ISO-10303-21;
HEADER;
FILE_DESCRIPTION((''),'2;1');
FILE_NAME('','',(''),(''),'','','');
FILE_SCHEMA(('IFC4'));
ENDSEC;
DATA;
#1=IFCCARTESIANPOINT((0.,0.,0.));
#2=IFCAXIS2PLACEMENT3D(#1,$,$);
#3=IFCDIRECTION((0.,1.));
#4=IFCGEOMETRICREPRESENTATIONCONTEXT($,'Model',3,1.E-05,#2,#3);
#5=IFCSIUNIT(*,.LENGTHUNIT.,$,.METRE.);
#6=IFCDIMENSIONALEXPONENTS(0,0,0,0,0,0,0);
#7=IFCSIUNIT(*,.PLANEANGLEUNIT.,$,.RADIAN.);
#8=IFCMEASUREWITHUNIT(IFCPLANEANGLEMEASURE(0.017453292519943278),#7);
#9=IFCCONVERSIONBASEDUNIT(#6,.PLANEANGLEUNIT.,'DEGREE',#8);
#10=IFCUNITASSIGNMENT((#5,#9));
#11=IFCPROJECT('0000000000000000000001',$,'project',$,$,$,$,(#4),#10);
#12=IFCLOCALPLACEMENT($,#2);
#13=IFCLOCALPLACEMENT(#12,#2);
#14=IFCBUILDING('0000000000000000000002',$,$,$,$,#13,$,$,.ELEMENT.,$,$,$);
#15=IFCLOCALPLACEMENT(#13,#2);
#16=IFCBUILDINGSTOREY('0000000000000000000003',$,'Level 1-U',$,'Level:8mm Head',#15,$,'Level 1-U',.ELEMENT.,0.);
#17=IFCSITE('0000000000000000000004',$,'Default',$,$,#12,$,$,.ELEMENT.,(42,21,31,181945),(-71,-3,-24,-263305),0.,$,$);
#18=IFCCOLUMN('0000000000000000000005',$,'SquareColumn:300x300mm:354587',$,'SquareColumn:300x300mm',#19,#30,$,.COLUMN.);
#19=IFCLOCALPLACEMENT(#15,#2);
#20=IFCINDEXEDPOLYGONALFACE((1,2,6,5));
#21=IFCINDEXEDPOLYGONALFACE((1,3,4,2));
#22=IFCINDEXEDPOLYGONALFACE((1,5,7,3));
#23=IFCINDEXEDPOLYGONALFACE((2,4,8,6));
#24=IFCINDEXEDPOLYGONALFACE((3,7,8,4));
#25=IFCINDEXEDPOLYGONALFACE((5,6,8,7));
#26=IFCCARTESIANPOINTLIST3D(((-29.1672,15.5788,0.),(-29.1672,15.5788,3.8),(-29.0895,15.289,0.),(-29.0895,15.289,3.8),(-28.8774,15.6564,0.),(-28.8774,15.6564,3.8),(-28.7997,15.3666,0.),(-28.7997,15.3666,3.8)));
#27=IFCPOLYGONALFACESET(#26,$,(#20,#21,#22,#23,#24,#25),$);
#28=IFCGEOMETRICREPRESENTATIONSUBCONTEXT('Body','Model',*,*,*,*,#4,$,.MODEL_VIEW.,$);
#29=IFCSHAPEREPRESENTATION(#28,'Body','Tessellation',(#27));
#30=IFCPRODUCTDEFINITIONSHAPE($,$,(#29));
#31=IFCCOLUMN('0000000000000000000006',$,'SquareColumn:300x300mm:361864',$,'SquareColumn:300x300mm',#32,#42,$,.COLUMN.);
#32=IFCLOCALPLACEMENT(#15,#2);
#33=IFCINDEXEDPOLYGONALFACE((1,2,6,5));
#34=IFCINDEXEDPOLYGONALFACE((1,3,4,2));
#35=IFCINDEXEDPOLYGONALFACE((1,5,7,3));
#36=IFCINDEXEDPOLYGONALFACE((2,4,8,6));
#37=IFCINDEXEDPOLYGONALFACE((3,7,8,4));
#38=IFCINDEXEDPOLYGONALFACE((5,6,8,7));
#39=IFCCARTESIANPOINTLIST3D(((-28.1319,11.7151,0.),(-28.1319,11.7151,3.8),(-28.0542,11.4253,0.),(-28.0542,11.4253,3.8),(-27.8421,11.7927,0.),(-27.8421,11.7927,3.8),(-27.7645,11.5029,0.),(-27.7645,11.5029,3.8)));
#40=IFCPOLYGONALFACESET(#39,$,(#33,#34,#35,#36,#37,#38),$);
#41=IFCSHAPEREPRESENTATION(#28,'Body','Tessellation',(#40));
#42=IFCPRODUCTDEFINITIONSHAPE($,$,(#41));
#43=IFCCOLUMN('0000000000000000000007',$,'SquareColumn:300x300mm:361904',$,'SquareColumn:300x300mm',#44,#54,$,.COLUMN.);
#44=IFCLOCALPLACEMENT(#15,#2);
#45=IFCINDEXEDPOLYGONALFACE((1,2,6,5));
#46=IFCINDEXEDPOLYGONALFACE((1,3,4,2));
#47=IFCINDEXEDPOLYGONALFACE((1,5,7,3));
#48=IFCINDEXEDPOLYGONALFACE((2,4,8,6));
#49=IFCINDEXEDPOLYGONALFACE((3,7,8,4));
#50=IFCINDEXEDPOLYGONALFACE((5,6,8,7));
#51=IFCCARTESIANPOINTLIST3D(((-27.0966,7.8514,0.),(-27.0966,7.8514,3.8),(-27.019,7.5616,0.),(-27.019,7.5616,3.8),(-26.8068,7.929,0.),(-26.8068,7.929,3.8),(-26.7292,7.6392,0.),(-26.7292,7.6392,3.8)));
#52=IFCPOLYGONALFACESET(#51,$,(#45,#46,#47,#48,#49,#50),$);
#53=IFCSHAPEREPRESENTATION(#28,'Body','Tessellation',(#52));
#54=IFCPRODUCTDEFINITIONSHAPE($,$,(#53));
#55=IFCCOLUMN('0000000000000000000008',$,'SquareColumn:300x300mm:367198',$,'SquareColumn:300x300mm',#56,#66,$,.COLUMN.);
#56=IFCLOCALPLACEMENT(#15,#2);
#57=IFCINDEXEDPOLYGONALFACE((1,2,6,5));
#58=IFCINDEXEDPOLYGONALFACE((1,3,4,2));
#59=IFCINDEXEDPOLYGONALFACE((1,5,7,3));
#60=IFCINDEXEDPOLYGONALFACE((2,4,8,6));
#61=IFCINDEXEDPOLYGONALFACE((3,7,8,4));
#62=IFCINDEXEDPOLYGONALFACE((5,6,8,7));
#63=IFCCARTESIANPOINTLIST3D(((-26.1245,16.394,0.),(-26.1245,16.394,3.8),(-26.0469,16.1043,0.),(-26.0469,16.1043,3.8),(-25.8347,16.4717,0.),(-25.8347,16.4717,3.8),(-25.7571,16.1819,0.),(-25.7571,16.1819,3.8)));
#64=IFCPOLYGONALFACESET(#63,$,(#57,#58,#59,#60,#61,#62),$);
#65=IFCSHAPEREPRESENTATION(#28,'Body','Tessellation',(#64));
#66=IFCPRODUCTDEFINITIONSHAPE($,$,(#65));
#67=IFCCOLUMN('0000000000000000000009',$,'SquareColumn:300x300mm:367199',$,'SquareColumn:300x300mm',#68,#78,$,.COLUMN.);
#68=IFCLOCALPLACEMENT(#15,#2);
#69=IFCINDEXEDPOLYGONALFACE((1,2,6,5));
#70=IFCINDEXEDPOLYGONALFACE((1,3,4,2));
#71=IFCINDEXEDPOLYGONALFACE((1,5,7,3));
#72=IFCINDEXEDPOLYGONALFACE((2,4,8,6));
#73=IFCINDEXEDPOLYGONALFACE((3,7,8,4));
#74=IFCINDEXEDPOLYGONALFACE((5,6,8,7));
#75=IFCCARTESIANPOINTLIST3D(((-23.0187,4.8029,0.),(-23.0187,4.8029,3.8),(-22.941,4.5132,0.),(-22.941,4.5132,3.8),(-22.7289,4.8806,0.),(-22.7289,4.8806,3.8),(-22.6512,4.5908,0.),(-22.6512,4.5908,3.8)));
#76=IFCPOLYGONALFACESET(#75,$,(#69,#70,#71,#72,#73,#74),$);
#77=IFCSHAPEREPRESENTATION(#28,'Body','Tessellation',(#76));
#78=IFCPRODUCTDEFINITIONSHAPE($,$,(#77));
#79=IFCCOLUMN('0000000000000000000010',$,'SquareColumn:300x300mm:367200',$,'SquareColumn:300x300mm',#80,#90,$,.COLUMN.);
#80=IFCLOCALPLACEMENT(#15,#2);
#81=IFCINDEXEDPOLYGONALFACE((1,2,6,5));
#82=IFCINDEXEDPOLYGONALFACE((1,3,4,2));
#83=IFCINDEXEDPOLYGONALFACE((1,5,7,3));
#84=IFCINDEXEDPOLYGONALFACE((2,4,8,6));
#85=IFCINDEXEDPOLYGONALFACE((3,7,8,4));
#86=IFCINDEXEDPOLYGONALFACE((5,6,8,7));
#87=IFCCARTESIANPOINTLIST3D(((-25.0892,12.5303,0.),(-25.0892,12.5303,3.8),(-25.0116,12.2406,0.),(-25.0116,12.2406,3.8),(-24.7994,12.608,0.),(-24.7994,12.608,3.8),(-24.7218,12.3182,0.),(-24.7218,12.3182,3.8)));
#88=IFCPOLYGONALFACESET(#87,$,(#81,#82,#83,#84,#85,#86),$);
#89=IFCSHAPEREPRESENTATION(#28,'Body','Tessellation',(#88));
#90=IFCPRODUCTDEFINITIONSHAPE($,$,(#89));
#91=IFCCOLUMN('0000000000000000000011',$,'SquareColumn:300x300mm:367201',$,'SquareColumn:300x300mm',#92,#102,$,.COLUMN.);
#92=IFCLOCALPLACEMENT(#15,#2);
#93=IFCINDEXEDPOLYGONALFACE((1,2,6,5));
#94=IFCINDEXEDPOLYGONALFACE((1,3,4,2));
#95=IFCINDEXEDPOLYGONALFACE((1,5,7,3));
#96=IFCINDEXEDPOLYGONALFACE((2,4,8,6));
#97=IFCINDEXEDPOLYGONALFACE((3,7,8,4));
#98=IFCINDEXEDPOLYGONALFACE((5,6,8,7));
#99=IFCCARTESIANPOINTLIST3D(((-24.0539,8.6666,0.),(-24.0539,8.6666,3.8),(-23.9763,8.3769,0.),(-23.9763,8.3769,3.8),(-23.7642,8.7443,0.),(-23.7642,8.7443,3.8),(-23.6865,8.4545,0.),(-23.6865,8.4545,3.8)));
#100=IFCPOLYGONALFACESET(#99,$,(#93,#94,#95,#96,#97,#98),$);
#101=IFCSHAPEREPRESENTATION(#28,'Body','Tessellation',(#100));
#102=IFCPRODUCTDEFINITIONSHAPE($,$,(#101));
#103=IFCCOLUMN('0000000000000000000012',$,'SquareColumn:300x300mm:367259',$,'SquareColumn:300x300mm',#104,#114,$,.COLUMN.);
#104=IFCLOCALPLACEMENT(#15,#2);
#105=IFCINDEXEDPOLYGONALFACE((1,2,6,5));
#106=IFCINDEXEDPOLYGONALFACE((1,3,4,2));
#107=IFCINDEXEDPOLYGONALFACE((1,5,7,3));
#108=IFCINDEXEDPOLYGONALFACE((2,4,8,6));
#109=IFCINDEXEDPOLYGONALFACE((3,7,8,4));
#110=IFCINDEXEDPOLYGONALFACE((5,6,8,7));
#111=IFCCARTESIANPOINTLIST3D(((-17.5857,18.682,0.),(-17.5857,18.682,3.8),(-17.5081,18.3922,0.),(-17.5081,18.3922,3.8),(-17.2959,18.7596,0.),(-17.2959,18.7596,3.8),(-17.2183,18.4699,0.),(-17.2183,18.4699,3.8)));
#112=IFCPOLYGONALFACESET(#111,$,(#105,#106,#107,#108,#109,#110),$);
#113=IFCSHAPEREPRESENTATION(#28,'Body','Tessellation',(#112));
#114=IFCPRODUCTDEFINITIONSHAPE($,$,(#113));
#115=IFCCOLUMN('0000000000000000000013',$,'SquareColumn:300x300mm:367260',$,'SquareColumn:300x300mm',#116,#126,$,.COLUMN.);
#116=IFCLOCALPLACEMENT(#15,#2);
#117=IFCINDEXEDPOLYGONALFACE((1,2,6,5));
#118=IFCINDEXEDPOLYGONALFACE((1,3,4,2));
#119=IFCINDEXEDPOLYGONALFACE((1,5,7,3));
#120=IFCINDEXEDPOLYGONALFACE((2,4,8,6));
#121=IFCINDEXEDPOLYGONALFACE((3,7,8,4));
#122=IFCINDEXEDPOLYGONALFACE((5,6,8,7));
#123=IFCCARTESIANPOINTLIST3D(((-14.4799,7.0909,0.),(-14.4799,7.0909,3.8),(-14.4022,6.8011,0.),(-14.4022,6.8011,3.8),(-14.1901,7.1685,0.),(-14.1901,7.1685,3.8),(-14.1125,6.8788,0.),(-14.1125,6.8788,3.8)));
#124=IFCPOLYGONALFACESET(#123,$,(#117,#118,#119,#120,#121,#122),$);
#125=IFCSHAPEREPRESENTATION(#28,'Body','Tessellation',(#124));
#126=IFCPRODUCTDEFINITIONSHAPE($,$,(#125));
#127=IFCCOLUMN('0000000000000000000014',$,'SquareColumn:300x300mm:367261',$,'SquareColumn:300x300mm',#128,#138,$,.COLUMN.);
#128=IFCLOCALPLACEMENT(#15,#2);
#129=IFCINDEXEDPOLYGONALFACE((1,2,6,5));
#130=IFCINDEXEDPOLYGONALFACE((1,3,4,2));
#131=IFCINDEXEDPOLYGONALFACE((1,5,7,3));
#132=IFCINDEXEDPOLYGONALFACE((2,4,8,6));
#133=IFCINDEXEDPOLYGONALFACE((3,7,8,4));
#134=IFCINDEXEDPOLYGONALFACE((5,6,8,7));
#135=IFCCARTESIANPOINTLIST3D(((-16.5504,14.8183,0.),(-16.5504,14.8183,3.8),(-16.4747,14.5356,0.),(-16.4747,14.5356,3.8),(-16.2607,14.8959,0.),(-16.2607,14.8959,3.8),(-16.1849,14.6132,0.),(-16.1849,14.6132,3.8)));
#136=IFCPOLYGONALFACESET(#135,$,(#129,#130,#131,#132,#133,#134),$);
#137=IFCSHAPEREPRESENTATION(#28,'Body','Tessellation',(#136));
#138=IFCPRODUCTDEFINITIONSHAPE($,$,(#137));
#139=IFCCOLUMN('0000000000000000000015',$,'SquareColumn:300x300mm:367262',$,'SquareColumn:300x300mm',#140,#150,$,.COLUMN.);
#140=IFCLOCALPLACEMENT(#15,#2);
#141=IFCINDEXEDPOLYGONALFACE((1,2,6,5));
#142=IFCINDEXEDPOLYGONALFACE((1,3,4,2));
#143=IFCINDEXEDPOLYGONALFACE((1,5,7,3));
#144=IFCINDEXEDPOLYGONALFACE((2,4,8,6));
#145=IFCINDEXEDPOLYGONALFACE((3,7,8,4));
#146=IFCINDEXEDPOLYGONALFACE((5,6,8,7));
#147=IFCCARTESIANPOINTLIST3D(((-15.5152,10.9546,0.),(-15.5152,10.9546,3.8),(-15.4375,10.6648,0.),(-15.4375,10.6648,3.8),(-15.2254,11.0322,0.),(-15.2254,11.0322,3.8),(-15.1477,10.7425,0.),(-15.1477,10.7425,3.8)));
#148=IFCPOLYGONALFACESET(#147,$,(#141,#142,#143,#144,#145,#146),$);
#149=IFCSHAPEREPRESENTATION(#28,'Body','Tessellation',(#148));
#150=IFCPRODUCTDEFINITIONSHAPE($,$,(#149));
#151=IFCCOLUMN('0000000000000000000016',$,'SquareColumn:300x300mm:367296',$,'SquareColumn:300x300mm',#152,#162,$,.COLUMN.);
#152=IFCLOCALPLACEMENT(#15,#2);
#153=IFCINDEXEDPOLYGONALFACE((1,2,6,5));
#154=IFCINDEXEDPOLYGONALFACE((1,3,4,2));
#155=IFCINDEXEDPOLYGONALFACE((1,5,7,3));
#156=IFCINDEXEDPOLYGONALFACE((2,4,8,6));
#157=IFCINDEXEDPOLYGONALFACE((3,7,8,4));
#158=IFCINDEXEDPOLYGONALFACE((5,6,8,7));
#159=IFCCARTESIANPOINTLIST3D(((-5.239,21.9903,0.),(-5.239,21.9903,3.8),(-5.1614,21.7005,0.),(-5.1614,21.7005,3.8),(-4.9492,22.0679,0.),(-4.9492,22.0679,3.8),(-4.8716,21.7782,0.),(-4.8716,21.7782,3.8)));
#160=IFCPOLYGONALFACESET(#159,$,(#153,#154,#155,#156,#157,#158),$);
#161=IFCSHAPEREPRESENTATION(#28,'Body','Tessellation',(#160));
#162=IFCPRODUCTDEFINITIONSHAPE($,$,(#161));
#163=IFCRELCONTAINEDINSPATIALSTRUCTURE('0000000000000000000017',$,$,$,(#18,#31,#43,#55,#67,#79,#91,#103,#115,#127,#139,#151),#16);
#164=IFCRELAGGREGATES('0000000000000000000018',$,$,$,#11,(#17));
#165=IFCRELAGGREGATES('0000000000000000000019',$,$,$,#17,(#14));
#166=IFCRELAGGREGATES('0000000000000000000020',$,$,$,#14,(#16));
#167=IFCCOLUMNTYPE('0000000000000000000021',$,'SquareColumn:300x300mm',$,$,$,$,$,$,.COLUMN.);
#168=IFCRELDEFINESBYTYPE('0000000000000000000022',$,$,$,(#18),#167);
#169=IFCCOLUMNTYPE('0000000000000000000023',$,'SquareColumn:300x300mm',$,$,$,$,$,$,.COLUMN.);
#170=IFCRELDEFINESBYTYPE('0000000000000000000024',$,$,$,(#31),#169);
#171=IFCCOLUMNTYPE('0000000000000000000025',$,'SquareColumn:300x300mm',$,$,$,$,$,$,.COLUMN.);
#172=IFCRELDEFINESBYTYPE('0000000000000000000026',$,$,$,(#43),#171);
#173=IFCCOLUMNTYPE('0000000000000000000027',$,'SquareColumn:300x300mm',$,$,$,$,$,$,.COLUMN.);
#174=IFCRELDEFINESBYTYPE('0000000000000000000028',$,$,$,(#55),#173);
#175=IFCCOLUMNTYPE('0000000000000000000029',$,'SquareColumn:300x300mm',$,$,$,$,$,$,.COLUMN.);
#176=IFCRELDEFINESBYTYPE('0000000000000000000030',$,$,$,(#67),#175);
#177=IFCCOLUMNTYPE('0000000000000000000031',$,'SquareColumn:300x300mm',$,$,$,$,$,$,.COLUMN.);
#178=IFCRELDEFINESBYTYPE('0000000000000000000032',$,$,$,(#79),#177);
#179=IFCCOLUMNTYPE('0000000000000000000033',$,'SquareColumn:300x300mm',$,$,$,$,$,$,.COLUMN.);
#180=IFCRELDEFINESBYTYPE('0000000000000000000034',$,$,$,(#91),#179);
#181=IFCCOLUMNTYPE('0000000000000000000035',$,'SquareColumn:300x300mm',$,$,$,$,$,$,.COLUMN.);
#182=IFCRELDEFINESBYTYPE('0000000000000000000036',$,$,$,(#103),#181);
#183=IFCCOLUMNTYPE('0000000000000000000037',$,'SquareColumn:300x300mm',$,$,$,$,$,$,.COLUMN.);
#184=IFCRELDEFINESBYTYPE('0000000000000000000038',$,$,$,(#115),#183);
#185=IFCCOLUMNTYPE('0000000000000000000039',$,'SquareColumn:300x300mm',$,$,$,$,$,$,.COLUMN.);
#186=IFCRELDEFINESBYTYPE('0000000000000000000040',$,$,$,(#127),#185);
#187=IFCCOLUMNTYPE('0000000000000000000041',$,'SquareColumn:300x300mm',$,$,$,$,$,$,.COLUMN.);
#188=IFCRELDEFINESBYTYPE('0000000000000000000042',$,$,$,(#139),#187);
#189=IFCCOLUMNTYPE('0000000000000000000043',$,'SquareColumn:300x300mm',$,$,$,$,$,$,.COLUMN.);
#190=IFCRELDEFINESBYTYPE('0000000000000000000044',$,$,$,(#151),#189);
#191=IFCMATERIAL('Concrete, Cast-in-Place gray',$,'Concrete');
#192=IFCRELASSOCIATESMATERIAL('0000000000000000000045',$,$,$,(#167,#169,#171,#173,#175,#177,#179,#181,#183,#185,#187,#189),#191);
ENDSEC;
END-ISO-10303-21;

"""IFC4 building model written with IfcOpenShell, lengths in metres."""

from ifc_helpers import new_model, entity, si_unit, converted_unit, direction, frame, frame_2d, origin, origin_2d_with_axis, place, context, subcontext, project, spatial, rectangle, extrude, source, transform, mapped, material, material_profile, profile_set, type_object, type_shapes, element, save


model = new_model("IFC4")

# Units and contexts
model_context = context("Model", 3, precision=1e-05, world=origin(), true_north=direction((0.0, 1.0)))
body_context = subcontext(model_context, "Body", "Model", "MODEL_VIEW")
ifc_project = project(units=[si_unit("LENGTHUNIT", "METRE"), converted_unit("PLANEANGLEUNIT", "DEGREE", entity("IfcPlaneAngleMeasure", 0.017453292519943278), si_unit("PLANEANGLEUNIT", "RADIAN"), dimensions=[0, 0, 0, 0, 0, 0, 0])], contexts=[model_context])

# Site, building, storey
site_placement = place(None, origin())
site = spatial("IfcSite", under=ifc_project, at=site_placement, Name="Default", CompositionType="ELEMENT", RefLatitude=(42, 21, 31, 181945), RefLongitude=(-71, -3, -24, -263305), RefElevation=0.0)
building_placement = place(site_placement, origin())
building = spatial("IfcBuilding", under=site, at=building_placement, CompositionType="ELEMENT")
storey_placement = place(building_placement, origin())
storey = spatial("IfcBuildingStorey", under=building, at=storey_placement, Name="Level 1-U", ObjectType="Level:8mm Head", LongName="Level 1-U", CompositionType="ELEMENT", Elevation=0.0)

# Columns
ifc_material_1 = material(Name="Concrete, Cast-in-Place gray", Category="Concrete")
ifc_material_profile = material_profile(ifc_material_1, rectangle(XDim=0.3, YDim=0.3, at=origin_2d_with_axis()), Name="300x300mm")
ifc_profile_set = profile_set([ifc_material_profile], Name="300x300mm")
column_type_1 = type_object("IfcColumnType", Name="SquareColumn:300x300mm", PredefinedType="COLUMN", material=ifc_profile_set)
shared_shape_1 = source(origin(), body_context, "Body", "SweptSolid", [
    extrude(rectangle(XDim=0.3, YDim=0.3, at=origin_2d_with_axis()), frame((-28.9835, 15.4727, 0.0), z_axis=(0.0, 0.0, 1.0), x_axis=(-0.258819, 0.965926, 0.0)), (0.0, 0.0, 1.0), 3.8),
])
type_shapes(column_type_1, [shared_shape_1])
column_1_placement = place(storey_placement, origin())
element("IfcColumn", 1, at=column_1_placement, inside=storey, type_object=column_type_1, Name="SquareColumn:300x300mm:354587", ObjectType="SquareColumn:300x300mm", PredefinedType="COLUMN", context=body_context, shape_type="MappedRepresentation", body=[
    mapped(shared_shape_1, transform((0.0, 0.0, 0.0), scale=1.0)),
])
column_type_2 = type_object("IfcColumnType", Name="SquareColumn:300x300mm", PredefinedType="COLUMN", material=ifc_profile_set)
shared_shape_2 = source(origin(), body_context, "Body", "SweptSolid", [
    extrude(rectangle(XDim=0.3, YDim=0.3, at=origin_2d_with_axis()), frame((-27.9482, 11.609, 0.0), z_axis=(0.0, 0.0, 1.0), x_axis=(-0.258819, 0.965926, 0.0)), (0.0, 0.0, 1.0), 3.8),
])
type_shapes(column_type_2, [shared_shape_2])
column_2_placement = place(storey_placement, origin())
element("IfcColumn", 2, at=column_2_placement, inside=storey, type_object=column_type_2, Name="SquareColumn:300x300mm:361864", ObjectType="SquareColumn:300x300mm", PredefinedType="COLUMN", context=body_context, shape_type="MappedRepresentation", body=[
    mapped(shared_shape_2, transform((0.0, 0.0, 0.0), scale=1.0)),
])
column_type_3 = type_object("IfcColumnType", Name="SquareColumn:300x300mm", PredefinedType="COLUMN", material=ifc_profile_set)
shared_shape_3 = source(origin(), body_context, "Body", "SweptSolid", [
    extrude(rectangle(XDim=0.3, YDim=0.3, at=origin_2d_with_axis()), frame((-26.9129, 7.7453, 0.0), z_axis=(0.0, 0.0, 1.0), x_axis=(-0.258819, 0.965926, 0.0)), (0.0, 0.0, 1.0), 3.8),
])
type_shapes(column_type_3, [shared_shape_3])
column_3_placement = place(storey_placement, origin())
element("IfcColumn", 3, at=column_3_placement, inside=storey, type_object=column_type_3, Name="SquareColumn:300x300mm:361904", ObjectType="SquareColumn:300x300mm", PredefinedType="COLUMN", context=body_context, shape_type="MappedRepresentation", body=[
    mapped(shared_shape_3, transform((0.0, 0.0, 0.0), scale=1.0)),
])
column_type_4 = type_object("IfcColumnType", Name="SquareColumn:300x300mm", PredefinedType="COLUMN", material=ifc_profile_set)
shared_shape_4 = source(origin(), body_context, "Body", "SweptSolid", [
    extrude(rectangle(XDim=0.3, YDim=0.3, at=origin_2d_with_axis()), frame((-25.9408, 16.288, 0.0), z_axis=(0.0, 0.0, 1.0), x_axis=(-0.258819, 0.965926, 0.0)), (0.0, 0.0, 1.0), 3.8),
])
type_shapes(column_type_4, [shared_shape_4])
column_4_placement = place(storey_placement, origin())
element("IfcColumn", 4, at=column_4_placement, inside=storey, type_object=column_type_4, Name="SquareColumn:300x300mm:367198", ObjectType="SquareColumn:300x300mm", PredefinedType="COLUMN", context=body_context, shape_type="MappedRepresentation", body=[
    mapped(shared_shape_4, transform((0.0, 0.0, 0.0), scale=1.0)),
])
column_type_5 = type_object("IfcColumnType", Name="SquareColumn:300x300mm", PredefinedType="COLUMN", material=ifc_profile_set)
shared_shape_5 = source(origin(), body_context, "Body", "SweptSolid", [
    extrude(rectangle(XDim=0.3, YDim=0.3, at=origin_2d_with_axis()), frame((-22.835, 4.6969, 0.0), z_axis=(0.0, 0.0, 1.0), x_axis=(-0.258819, 0.965926, 0.0)), (0.0, 0.0, 1.0), 3.8),
])
type_shapes(column_type_5, [shared_shape_5])
column_5_placement = place(storey_placement, origin())
element("IfcColumn", 5, at=column_5_placement, inside=storey, type_object=column_type_5, Name="SquareColumn:300x300mm:367199", ObjectType="SquareColumn:300x300mm", PredefinedType="COLUMN", context=body_context, shape_type="MappedRepresentation", body=[
    mapped(shared_shape_5, transform((0.0, 0.0, 0.0), scale=1.0)),
])
column_type_6 = type_object("IfcColumnType", Name="SquareColumn:300x300mm", PredefinedType="COLUMN", material=ifc_profile_set)
shared_shape_6 = source(origin(), body_context, "Body", "SweptSolid", [
    extrude(rectangle(XDim=0.3, YDim=0.3, at=origin_2d_with_axis()), frame((-24.9055, 12.4243, 0.0), z_axis=(0.0, 0.0, 1.0), x_axis=(-0.258819, 0.965926, 0.0)), (0.0, 0.0, 1.0), 3.8),
])
type_shapes(column_type_6, [shared_shape_6])
column_6_placement = place(storey_placement, origin())
element("IfcColumn", 6, at=column_6_placement, inside=storey, type_object=column_type_6, Name="SquareColumn:300x300mm:367200", ObjectType="SquareColumn:300x300mm", PredefinedType="COLUMN", context=body_context, shape_type="MappedRepresentation", body=[
    mapped(shared_shape_6, transform((0.0, 0.0, 0.0), scale=1.0)),
])
column_type_7 = type_object("IfcColumnType", Name="SquareColumn:300x300mm", PredefinedType="COLUMN", material=ifc_profile_set)
shared_shape_7 = source(origin(), body_context, "Body", "SweptSolid", [
    extrude(rectangle(XDim=0.3, YDim=0.3, at=origin_2d_with_axis()), frame((-23.8702, 8.5606, 0.0), z_axis=(0.0, 0.0, 1.0), x_axis=(-0.258819, 0.965926, 0.0)), (0.0, 0.0, 1.0), 3.8),
])
type_shapes(column_type_7, [shared_shape_7])
column_7_placement = place(storey_placement, origin())
element("IfcColumn", 7, at=column_7_placement, inside=storey, type_object=column_type_7, Name="SquareColumn:300x300mm:367201", ObjectType="SquareColumn:300x300mm", PredefinedType="COLUMN", context=body_context, shape_type="MappedRepresentation", body=[
    mapped(shared_shape_7, transform((0.0, 0.0, 0.0), scale=1.0)),
])
column_type_8 = type_object("IfcColumnType", Name="SquareColumn:300x300mm", PredefinedType="COLUMN", material=ifc_profile_set)
shared_shape_8 = source(origin(), body_context, "Body", "SweptSolid", [
    extrude(rectangle(XDim=0.3, YDim=0.3, at=origin_2d_with_axis()), frame((-17.402, 18.5759, 0.0), z_axis=(0.0, 0.0, 1.0), x_axis=(-0.258819, 0.965926, 0.0)), (0.0, 0.0, 1.0), 3.8),
])
type_shapes(column_type_8, [shared_shape_8])
column_8_placement = place(storey_placement, origin())
element("IfcColumn", 8, at=column_8_placement, inside=storey, type_object=column_type_8, Name="SquareColumn:300x300mm:367259", ObjectType="SquareColumn:300x300mm", PredefinedType="COLUMN", context=body_context, shape_type="MappedRepresentation", body=[
    mapped(shared_shape_8, transform((0.0, 0.0, 0.0), scale=1.0)),
])
column_type_9 = type_object("IfcColumnType", Name="SquareColumn:300x300mm", PredefinedType="COLUMN", material=ifc_profile_set)
shared_shape_9 = source(origin(), body_context, "Body", "SweptSolid", [
    extrude(rectangle(XDim=0.3, YDim=0.3, at=frame_2d((0.0, 0.0), x_axis=(1.0, 0.0))), frame((-14.2962, 6.9848, 0.0), z_axis=(0.0, 0.0, 1.0), x_axis=(-0.258819, 0.965926, 0.0)), (0.0, 0.0, 1.0), 3.8),
])
type_shapes(column_type_9, [shared_shape_9])
column_9_placement = place(storey_placement, origin())
element("IfcColumn", 9, at=column_9_placement, inside=storey, type_object=column_type_9, Name="SquareColumn:300x300mm:367260", ObjectType="SquareColumn:300x300mm", PredefinedType="COLUMN", context=body_context, shape_type="MappedRepresentation", body=[
    mapped(shared_shape_9, transform((0.0, 0.0, 0.0), scale=1.0)),
])
column_type_10 = type_object("IfcColumnType", Name="SquareColumn:300x300mm", PredefinedType="COLUMN", material=ifc_profile_set)
shared_shape_10 = source(origin(), body_context, "Body", "SweptSolid", [
    extrude(rectangle(XDim=0.2927, YDim=0.3, at=frame_2d((0.0, 0.0), x_axis=(1.0, 0.0))), frame((-16.3677, 14.7157, 0.0), z_axis=(0.0, 0.0, 1.0), x_axis=(-0.258819, 0.965926, 0.0)), (0.0, 0.0, 1.0), 3.8),
])
type_shapes(column_type_10, [shared_shape_10])
column_10_placement = place(storey_placement, origin())
element("IfcColumn", 10, at=column_10_placement, inside=storey, type_object=column_type_10, Name="SquareColumn:300x300mm:367261", ObjectType="SquareColumn:300x300mm", PredefinedType="COLUMN", context=body_context, shape_type="MappedRepresentation", body=[
    mapped(shared_shape_10, transform((0.0, 0.0, 0.0), scale=1.0)),
])
column_type_11 = type_object("IfcColumnType", Name="SquareColumn:300x300mm", PredefinedType="COLUMN", material=ifc_profile_set)
shared_shape_11 = source(origin(), body_context, "Body", "SweptSolid", [
    extrude(rectangle(XDim=0.3, YDim=0.3, at=frame_2d((0.0, 0.0), x_axis=(1.0, 0.0))), frame((-15.3314, 10.8485, 0.0), z_axis=(0.0, 0.0, 1.0), x_axis=(-0.258819, 0.965926, 0.0)), (0.0, 0.0, 1.0), 3.8),
])
type_shapes(column_type_11, [shared_shape_11])
column_11_placement = place(storey_placement, origin())
element("IfcColumn", 11, at=column_11_placement, inside=storey, type_object=column_type_11, Name="SquareColumn:300x300mm:367262", ObjectType="SquareColumn:300x300mm", PredefinedType="COLUMN", context=body_context, shape_type="MappedRepresentation", body=[
    mapped(shared_shape_11, transform((0.0, 0.0, 0.0), scale=1.0)),
])
column_type_12 = type_object("IfcColumnType", Name="SquareColumn:300x300mm", PredefinedType="COLUMN", material=ifc_profile_set)
shared_shape_12 = source(origin(), body_context, "Body", "SweptSolid", [
    extrude(rectangle(XDim=0.3, YDim=0.3, at=frame_2d((0.0, 0.0), x_axis=(1.0, 0.0))), frame((-5.0553, 21.8842, 0.0), z_axis=(0.0, 0.0, 1.0), x_axis=(-0.258819, 0.965926, 0.0)), (0.0, 0.0, 1.0), 3.8),
])
type_shapes(column_type_12, [shared_shape_12])
column_12_placement = place(storey_placement, origin())
element("IfcColumn", 12, at=column_12_placement, inside=storey, type_object=column_type_12, Name="SquareColumn:300x300mm:367296", ObjectType="SquareColumn:300x300mm", PredefinedType="COLUMN", context=body_context, shape_type="MappedRepresentation", body=[
    mapped(shared_shape_12, transform((0.0, 0.0, 0.0), scale=1.0)),
])

save(model, "model.ifc")
